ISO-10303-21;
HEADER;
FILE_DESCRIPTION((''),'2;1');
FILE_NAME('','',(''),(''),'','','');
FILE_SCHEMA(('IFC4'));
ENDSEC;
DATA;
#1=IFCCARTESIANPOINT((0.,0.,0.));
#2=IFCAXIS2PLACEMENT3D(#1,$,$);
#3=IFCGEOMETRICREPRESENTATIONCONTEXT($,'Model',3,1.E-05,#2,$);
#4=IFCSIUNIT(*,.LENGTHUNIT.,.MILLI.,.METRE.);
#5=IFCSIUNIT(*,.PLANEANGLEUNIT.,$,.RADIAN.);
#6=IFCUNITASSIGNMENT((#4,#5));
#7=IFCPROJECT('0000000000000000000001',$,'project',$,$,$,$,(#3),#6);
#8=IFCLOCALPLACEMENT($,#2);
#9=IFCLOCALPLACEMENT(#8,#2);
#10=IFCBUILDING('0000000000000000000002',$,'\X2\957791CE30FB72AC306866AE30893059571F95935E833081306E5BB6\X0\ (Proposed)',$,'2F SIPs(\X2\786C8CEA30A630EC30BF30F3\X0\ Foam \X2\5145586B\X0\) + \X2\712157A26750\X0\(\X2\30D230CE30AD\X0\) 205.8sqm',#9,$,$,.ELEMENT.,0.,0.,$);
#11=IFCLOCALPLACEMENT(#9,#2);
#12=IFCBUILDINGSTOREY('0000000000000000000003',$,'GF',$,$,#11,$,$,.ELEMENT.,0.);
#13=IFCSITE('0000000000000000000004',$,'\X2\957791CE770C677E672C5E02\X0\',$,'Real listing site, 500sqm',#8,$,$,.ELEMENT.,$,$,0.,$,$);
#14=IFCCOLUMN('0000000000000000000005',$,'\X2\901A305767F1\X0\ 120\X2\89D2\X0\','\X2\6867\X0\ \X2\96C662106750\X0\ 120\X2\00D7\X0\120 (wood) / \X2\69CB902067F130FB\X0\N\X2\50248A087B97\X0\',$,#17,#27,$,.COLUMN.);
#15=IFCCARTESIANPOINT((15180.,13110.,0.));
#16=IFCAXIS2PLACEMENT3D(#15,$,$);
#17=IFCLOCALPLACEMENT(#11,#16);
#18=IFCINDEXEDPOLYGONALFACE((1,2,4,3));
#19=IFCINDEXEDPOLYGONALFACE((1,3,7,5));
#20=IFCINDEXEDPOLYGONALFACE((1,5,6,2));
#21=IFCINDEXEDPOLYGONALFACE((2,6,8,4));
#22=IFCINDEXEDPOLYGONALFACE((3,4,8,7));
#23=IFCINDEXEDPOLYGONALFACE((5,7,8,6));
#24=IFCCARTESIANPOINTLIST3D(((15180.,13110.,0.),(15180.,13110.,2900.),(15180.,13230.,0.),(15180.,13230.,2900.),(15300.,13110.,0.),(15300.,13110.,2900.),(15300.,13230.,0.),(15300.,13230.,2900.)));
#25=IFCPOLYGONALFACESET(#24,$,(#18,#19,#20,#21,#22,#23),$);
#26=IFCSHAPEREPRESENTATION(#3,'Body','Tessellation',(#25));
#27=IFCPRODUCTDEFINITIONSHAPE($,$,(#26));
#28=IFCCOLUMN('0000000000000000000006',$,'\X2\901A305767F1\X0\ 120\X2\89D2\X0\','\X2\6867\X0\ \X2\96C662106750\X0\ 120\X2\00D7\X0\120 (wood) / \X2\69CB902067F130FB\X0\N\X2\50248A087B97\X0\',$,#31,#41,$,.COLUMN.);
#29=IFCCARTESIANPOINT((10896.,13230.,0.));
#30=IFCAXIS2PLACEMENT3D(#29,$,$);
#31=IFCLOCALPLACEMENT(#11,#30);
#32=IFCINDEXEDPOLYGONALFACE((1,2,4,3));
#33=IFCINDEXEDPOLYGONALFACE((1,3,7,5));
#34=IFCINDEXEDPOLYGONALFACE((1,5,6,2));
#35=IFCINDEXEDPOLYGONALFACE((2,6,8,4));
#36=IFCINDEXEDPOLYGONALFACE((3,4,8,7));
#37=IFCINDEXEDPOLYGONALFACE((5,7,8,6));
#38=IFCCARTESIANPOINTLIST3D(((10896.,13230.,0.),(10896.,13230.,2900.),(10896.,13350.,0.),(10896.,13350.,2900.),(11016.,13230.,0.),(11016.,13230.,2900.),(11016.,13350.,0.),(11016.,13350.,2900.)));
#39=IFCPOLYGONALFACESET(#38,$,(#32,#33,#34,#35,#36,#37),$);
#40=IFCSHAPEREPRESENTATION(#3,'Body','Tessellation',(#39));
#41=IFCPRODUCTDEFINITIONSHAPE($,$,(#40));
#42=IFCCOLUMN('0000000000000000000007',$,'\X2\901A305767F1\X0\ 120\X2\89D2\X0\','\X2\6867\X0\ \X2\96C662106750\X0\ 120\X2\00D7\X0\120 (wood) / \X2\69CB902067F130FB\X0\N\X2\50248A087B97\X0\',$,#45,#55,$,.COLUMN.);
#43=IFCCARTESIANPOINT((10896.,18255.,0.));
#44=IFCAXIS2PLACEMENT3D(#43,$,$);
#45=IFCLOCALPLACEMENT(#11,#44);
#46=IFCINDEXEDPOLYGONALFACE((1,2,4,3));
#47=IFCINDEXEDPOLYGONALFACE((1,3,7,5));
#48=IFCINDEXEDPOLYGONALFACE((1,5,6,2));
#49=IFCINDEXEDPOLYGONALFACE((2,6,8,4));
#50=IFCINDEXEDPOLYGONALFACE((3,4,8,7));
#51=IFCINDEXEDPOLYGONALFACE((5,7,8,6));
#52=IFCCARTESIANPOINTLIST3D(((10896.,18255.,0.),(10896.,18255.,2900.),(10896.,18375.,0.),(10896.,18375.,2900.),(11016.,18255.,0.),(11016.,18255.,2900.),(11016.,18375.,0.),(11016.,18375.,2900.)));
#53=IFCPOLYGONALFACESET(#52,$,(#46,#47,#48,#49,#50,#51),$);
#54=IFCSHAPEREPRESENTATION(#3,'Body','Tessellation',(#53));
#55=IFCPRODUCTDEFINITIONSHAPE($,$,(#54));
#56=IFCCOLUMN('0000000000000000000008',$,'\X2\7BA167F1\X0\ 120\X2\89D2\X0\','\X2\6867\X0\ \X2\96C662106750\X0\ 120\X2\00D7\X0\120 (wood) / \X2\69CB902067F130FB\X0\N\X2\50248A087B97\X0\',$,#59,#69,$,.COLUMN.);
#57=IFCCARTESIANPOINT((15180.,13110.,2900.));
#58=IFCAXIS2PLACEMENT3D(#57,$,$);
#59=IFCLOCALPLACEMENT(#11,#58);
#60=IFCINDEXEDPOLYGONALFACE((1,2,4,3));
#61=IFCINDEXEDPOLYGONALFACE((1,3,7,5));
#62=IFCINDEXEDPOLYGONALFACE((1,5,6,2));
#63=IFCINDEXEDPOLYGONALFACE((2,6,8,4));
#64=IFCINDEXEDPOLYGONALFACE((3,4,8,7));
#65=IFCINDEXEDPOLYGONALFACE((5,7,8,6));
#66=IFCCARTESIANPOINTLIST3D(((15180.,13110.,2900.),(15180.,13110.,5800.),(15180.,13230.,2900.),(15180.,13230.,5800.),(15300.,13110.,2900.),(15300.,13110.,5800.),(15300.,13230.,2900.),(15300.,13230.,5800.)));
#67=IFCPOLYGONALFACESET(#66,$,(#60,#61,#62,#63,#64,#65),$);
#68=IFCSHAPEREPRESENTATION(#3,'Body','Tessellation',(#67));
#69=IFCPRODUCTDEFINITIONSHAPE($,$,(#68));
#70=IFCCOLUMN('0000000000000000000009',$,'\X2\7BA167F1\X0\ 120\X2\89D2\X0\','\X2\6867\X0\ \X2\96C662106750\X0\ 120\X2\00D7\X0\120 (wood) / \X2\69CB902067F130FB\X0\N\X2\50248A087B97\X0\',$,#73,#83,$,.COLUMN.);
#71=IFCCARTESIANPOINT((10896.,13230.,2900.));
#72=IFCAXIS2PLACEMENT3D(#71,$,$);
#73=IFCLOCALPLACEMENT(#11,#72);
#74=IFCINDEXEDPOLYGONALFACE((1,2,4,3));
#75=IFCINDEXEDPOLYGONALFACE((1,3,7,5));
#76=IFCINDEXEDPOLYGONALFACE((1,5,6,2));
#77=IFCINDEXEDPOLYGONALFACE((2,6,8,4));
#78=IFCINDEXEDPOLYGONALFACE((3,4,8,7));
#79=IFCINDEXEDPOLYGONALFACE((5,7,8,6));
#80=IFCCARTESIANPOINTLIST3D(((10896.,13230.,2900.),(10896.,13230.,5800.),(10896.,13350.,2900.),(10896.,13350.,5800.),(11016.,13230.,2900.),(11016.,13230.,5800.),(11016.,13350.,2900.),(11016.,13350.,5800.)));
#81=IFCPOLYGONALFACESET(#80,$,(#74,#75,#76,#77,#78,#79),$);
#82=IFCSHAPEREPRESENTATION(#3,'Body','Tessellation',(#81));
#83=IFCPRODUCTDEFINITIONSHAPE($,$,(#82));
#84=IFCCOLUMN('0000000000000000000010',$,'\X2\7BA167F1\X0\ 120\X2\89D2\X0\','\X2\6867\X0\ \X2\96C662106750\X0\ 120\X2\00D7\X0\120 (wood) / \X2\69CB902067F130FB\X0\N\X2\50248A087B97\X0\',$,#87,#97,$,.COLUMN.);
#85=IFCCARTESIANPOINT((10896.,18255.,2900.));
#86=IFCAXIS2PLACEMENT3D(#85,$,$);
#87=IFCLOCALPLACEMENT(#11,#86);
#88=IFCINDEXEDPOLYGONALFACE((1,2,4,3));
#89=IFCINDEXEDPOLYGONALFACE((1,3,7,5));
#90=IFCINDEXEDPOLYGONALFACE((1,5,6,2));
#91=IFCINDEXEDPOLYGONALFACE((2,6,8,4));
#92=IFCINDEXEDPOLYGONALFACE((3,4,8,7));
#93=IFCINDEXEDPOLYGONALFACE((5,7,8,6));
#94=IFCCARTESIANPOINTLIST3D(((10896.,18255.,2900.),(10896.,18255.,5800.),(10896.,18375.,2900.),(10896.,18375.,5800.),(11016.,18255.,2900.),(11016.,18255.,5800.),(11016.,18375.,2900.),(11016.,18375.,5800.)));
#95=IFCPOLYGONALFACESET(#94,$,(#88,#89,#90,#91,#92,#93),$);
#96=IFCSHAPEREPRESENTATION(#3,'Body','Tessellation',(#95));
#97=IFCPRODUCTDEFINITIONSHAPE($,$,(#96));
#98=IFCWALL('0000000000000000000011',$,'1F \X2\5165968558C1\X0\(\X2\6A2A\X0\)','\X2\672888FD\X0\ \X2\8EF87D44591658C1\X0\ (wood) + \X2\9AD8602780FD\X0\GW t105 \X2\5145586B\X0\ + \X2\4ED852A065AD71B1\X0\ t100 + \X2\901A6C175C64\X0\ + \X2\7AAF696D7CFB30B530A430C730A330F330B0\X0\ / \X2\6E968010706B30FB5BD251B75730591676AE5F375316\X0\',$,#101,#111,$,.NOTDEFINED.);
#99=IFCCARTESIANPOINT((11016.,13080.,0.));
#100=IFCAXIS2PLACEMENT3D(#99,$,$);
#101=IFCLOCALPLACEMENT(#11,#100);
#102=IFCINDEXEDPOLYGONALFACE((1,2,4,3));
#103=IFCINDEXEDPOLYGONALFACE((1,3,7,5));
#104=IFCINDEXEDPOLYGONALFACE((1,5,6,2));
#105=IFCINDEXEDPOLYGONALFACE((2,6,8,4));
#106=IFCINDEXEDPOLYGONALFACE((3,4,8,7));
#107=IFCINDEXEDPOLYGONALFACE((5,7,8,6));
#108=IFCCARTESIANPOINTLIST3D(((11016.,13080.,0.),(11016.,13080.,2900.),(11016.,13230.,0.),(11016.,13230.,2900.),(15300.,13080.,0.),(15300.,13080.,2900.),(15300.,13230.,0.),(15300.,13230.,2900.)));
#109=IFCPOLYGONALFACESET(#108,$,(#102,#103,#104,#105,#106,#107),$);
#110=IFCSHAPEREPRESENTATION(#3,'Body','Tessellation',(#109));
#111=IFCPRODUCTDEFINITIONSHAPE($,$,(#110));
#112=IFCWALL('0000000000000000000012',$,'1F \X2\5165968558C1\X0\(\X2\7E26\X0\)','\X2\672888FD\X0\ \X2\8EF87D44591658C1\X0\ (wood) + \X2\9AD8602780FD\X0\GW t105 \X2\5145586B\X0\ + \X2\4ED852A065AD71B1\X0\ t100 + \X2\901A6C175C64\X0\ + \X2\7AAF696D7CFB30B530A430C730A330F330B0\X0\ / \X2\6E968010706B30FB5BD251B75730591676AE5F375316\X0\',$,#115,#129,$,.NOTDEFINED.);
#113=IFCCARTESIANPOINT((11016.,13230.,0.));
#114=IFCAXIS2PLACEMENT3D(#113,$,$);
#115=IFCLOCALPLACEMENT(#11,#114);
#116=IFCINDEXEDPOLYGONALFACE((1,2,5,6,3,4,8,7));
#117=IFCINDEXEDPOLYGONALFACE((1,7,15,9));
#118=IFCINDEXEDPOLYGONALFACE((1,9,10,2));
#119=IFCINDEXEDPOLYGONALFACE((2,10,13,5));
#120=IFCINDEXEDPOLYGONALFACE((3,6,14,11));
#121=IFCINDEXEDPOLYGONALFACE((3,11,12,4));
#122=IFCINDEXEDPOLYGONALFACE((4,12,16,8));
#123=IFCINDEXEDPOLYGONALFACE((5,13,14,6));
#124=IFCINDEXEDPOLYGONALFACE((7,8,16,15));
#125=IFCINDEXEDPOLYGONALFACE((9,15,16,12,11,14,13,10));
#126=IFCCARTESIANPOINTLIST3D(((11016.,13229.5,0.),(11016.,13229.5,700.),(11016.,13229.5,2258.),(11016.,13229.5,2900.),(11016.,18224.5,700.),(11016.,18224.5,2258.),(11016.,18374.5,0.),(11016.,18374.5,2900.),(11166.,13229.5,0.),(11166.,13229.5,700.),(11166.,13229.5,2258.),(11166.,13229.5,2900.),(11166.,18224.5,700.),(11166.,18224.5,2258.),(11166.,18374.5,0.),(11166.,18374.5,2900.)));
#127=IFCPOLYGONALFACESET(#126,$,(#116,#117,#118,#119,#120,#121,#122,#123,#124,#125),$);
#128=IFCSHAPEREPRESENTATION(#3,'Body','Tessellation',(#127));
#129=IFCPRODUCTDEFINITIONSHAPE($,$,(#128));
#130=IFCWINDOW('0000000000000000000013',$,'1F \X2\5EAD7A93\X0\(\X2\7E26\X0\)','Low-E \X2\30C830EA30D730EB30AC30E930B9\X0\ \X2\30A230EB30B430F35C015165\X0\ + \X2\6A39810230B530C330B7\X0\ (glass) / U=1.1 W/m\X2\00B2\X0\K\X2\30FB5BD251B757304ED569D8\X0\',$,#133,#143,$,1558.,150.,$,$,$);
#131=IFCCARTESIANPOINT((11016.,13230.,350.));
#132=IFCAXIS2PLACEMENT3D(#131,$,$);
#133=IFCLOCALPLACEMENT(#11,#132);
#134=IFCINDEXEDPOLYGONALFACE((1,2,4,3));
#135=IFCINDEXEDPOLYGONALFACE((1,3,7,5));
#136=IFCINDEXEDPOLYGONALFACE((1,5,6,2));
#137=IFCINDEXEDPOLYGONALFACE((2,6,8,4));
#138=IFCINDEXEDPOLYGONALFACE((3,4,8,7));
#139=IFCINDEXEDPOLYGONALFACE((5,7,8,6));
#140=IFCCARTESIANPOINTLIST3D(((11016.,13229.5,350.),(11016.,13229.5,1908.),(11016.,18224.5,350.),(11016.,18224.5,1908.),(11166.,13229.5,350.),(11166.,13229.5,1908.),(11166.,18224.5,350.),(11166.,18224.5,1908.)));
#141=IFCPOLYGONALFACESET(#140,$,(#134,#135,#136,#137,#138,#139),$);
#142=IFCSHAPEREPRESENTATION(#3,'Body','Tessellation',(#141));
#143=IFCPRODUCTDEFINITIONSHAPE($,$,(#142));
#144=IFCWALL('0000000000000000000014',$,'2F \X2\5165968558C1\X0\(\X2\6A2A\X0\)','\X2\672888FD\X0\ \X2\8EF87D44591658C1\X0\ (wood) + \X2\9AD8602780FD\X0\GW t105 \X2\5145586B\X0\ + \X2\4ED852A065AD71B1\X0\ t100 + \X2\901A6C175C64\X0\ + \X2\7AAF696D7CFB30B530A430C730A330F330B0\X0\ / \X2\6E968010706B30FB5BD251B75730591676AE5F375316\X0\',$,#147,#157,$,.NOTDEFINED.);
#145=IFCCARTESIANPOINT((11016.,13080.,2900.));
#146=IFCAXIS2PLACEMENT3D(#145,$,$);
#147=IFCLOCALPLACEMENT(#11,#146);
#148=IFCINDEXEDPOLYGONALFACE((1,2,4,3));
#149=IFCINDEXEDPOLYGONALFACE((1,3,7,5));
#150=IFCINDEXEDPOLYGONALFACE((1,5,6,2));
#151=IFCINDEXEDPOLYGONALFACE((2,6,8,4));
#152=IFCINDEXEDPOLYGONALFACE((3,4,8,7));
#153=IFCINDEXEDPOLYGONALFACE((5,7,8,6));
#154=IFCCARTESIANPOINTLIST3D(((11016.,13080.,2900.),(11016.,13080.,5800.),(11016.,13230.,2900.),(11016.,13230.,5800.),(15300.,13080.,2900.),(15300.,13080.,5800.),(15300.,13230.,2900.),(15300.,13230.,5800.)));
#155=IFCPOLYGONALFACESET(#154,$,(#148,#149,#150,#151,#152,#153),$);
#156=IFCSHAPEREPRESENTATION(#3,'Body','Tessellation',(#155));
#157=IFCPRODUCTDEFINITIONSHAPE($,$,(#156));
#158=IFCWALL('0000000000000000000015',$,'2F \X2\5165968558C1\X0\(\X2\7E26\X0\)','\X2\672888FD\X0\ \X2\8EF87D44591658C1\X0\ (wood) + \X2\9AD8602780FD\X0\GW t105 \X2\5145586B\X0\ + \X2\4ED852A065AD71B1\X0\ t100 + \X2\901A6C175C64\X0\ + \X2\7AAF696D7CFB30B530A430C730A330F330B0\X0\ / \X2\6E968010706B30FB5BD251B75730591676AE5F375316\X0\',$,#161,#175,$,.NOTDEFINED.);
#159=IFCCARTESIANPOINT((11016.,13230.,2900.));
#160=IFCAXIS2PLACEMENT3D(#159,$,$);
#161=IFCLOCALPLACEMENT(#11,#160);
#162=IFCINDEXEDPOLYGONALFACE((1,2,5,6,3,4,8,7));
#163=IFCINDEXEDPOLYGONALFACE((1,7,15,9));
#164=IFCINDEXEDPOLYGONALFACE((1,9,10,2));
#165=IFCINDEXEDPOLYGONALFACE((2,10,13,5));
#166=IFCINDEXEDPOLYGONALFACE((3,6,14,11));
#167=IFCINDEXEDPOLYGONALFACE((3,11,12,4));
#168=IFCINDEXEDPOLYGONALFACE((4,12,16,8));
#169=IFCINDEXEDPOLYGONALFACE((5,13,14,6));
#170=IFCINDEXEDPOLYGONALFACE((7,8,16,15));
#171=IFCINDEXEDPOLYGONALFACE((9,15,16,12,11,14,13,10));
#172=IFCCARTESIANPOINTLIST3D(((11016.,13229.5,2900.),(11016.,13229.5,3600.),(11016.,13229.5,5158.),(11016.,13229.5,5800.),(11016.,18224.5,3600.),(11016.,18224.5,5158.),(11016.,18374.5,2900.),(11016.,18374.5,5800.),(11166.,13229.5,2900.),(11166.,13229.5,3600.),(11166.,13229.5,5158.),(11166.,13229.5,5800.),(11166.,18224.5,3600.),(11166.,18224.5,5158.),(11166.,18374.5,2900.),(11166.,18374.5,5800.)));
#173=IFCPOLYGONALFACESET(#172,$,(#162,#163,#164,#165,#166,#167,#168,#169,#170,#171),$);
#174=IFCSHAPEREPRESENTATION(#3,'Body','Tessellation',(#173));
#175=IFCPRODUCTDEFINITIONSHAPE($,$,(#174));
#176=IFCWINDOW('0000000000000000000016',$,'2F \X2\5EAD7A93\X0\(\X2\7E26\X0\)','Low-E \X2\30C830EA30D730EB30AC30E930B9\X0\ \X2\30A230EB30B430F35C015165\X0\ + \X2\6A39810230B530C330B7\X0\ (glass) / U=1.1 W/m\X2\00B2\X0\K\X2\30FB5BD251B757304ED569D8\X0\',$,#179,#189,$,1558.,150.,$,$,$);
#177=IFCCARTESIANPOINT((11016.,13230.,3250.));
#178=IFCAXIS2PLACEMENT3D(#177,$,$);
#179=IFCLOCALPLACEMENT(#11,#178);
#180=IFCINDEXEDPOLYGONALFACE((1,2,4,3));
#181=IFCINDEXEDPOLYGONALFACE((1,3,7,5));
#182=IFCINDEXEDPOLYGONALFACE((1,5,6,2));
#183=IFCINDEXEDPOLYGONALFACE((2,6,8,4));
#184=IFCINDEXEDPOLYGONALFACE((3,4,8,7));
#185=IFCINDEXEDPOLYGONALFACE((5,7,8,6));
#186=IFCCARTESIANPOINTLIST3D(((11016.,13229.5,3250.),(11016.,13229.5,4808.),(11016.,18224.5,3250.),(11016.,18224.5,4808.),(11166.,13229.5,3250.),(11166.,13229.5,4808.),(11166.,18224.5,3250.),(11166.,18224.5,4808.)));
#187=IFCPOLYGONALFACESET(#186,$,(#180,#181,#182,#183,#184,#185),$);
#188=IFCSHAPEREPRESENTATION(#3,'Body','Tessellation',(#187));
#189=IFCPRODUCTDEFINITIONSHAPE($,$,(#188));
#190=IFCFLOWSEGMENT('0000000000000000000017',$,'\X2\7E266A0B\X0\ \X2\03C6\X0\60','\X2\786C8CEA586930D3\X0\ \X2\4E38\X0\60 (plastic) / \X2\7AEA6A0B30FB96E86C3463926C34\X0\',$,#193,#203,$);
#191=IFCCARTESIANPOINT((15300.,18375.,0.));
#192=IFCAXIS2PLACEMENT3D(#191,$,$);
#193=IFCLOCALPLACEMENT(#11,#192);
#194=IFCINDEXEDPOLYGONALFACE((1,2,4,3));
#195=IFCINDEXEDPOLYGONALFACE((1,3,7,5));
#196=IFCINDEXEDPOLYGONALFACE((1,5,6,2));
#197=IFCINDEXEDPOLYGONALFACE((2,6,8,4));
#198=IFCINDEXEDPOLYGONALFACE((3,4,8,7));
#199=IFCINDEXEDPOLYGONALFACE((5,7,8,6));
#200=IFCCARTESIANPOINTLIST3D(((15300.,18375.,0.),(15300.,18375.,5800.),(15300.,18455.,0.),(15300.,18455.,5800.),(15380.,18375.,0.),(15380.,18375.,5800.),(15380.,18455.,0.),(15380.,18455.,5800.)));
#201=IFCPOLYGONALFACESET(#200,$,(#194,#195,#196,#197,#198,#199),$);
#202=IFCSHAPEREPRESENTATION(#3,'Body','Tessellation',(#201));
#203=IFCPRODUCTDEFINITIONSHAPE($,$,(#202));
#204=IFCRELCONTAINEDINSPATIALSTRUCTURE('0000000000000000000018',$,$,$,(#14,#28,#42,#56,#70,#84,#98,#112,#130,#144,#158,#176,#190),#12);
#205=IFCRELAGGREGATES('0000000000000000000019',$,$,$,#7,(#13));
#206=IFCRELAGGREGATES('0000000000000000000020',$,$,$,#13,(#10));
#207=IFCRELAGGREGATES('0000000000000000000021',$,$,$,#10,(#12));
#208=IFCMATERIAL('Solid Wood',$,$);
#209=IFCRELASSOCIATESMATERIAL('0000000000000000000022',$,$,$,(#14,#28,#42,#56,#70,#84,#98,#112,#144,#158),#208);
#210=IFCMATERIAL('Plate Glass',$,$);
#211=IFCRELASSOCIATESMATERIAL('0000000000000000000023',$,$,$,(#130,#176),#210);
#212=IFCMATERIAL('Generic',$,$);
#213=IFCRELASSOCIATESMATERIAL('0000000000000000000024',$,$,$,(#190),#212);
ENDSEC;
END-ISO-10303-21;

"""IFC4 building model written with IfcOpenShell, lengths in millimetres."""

from ifc_helpers import new_model, si_unit, frame, frame_2d, origin, place, context, project, spatial, rectangle, extrude, material, element, fill, save


model = new_model("IFC4")

# Units and contexts
model_context = context("Model", 3, precision=1e-05, world=origin())
ifc_project = project(units=[si_unit("LENGTHUNIT", "METRE", prefix="MILLI"), si_unit("PLANEANGLEUNIT", "RADIAN")], contexts=[model_context])

# Site, building, storey
site_placement = place(None, origin())
site = spatial("IfcSite", under=ifc_project, at=site_placement, Name="長野県松本市", ObjectType="Real listing site, 500sqm", CompositionType="ELEMENT", RefElevation=0.0)
building_placement = place(site_placement, origin())
building = spatial("IfcBuilding", under=site, at=building_placement, Name="長野・犬と暮らす土間広めの家 (Proposed)", ObjectType="2F SIPs(硬質ウレタン Foam 充填) + 無垢材(ヒノキ) 205.8sqm", CompositionType="ELEMENT", ElevationOfRefHeight=0.0, ElevationOfTerrain=0.0)
storey_placement = place(building_placement, origin())
storey = spatial("IfcBuildingStorey", under=building, at=storey_placement, Name="GF", CompositionType="ELEMENT", Elevation=0.0)

# Columns
ifc_material_1 = material(Name="Solid Wood")
column_1_placement = place(storey_placement, frame((15180.0, 13110.0, 0.0)))
element("IfcColumn", 1, at=column_1_placement, inside=storey, material=ifc_material_1, Name="通し柱 120角", Description="桧 集成材 120×120 (wood) / 構造柱・N値計算", PredefinedType="COLUMN", context=model_context, shape_type="SweptSolid", body=[
    extrude(rectangle(XDim=120.0, YDim=120.0, at=frame_2d((60.0, 60.0))), frame((15180.0, 13110.0, 0.0)), (0.0, 0.0, 1.0), 2900.0),
])
column_2_placement = place(storey_placement, frame((10896.0, 13230.0, 0.0)))
element("IfcColumn", 2, at=column_2_placement, inside=storey, material=ifc_material_1, Name="通し柱 120角", Description="桧 集成材 120×120 (wood) / 構造柱・N値計算", PredefinedType="COLUMN", context=model_context, shape_type="SweptSolid", body=[
    extrude(rectangle(XDim=120.0, YDim=120.0, at=frame_2d((60.0, 60.0))), frame((10896.0, 13230.0, 0.0)), (0.0, 0.0, 1.0), 2900.0),
])
column_3_placement = place(storey_placement, frame((10896.0, 18255.0, 0.0)))
element("IfcColumn", 3, at=column_3_placement, inside=storey, material=ifc_material_1, Name="通し柱 120角", Description="桧 集成材 120×120 (wood) / 構造柱・N値計算", PredefinedType="COLUMN", context=model_context, shape_type="SweptSolid", body=[
    extrude(rectangle(XDim=120.0, YDim=120.0, at=frame_2d((60.0, 60.0))), frame((10896.0, 18255.0, 0.0)), (0.0, 0.0, 1.0), 2900.0),
])
column_4_placement = place(storey_placement, frame((15180.0, 13110.0, 2900.0)))
element("IfcColumn", 4, at=column_4_placement, inside=storey, material=ifc_material_1, Name="管柱 120角", Description="桧 集成材 120×120 (wood) / 構造柱・N値計算", PredefinedType="COLUMN", context=model_context, shape_type="SweptSolid", body=[
    extrude(rectangle(XDim=120.0, YDim=120.0, at=frame_2d((60.0, 60.0))), frame((15180.0, 13110.0, 2900.0)), (0.0, 0.0, 1.0), 2900.0),
])
column_5_placement = place(storey_placement, frame((10896.0, 13230.0, 2900.0)))
element("IfcColumn", 5, at=column_5_placement, inside=storey, material=ifc_material_1, Name="管柱 120角", Description="桧 集成材 120×120 (wood) / 構造柱・N値計算", PredefinedType="COLUMN", context=model_context, shape_type="SweptSolid", body=[
    extrude(rectangle(XDim=120.0, YDim=120.0, at=frame_2d((60.0, 60.0))), frame((10896.0, 13230.0, 2900.0)), (0.0, 0.0, 1.0), 2900.0),
])
column_6_placement = place(storey_placement, frame((10896.0, 18255.0, 2900.0)))
element("IfcColumn", 6, at=column_6_placement, inside=storey, material=ifc_material_1, Name="管柱 120角", Description="桧 集成材 120×120 (wood) / 構造柱・N値計算", PredefinedType="COLUMN", context=model_context, shape_type="SweptSolid", body=[
    extrude(rectangle(XDim=120.0, YDim=120.0, at=frame_2d((60.0, 60.0))), frame((10896.0, 18255.0, 2900.0)), (0.0, 0.0, 1.0), 2900.0),
])

# Wall
wall_1_placement = place(storey_placement, frame((11016.0, 13080.0, 0.0)))
element("IfcWall", 7, at=wall_1_placement, inside=storey, material=ifc_material_1, Name="1F 入隅壁(横)", Description="木製 軸組外壁 (wood) + 高性能GW t105 充填 + 付加断熱 t100 + 通気層 + 窯業系サイディング / 準耐火・寒冷地外皮強化", PredefinedType="NOTDEFINED", context=model_context, shape_type="SweptSolid", body=[
    extrude(rectangle(XDim=4284.0, YDim=150.0, at=frame_2d((2142.0, 75.0))), frame((11016.0, 13080.0, 0.0)), (0.0, 0.0, 1.0), 2900.0),
])

# Wall, opening, window
wall_2_placement = place(storey_placement, frame((11016.0, 13230.0, 0.0)))
wall_2 = element("IfcWall", 8, at=wall_2_placement, inside=storey, material=ifc_material_1, Name="1F 入隅壁(縦)", Description="木製 軸組外壁 (wood) + 高性能GW t105 充填 + 付加断熱 t100 + 通気層 + 窯業系サイディング / 準耐火・寒冷地外皮強化", PredefinedType="NOTDEFINED", context=model_context, shape_type="SweptSolid", body=[
    extrude(rectangle(XDim=150.0, YDim=5145.0, at=frame_2d((75.0, 2572.0))), frame((11016.0, 13230.0, 0.0)), (0.0, 0.0, 1.0), 2900.0),
])
opening_1_placement = place(storey_placement, frame((11016.0, 13230.0, 350.0)))
opening_1 = element("IfcOpeningElement", 9, at=opening_1_placement, cuts=wall_2, PredefinedType="NOTDEFINED", context=model_context, shape_type="SweptSolid", body=[
    extrude(rectangle(XDim=150.0, YDim=4995.0, at=frame_2d((75.0, 2497.0))), frame((11016.0, 13230.0, 350.0)), (0.0, 0.0, 1.0), 1558.0),
])
ifc_material_2 = material(Name="Plate Glass")
window_1_placement = place(storey_placement, frame((11016.0, 13230.0, 350.0)))
window_1 = element("IfcWindow", 10, at=window_1_placement, inside=storey, material=ifc_material_2, Name="1F 庭窓(縦)", Description="Low-E トリプルガラス アルゴン封入 + 樹脂サッシ (glass) / U=1.1 W/m²K・寒冷地仕様", OverallHeight=1558.0, OverallWidth=150.0, context=model_context, shape_type="SweptSolid", body=[
    extrude(rectangle(XDim=150.0, YDim=4995.0, at=frame_2d((75.0, 2497.0))), frame((11016.0, 13230.0, 350.0)), (0.0, 0.0, 1.0), 1558.0),
])
fill(opening_1, window_1)

# Wall
wall_3_placement = place(storey_placement, frame((11016.0, 13080.0, 2900.0)))
element("IfcWall", 11, at=wall_3_placement, inside=storey, material=ifc_material_1, Name="2F 入隅壁(横)", Description="木製 軸組外壁 (wood) + 高性能GW t105 充填 + 付加断熱 t100 + 通気層 + 窯業系サイディング / 準耐火・寒冷地外皮強化", PredefinedType="NOTDEFINED", context=model_context, shape_type="SweptSolid", body=[
    extrude(rectangle(XDim=4284.0, YDim=150.0, at=frame_2d((2142.0, 75.0))), frame((11016.0, 13080.0, 2900.0)), (0.0, 0.0, 1.0), 2900.0),
])

# Wall, opening, window
wall_4_placement = place(storey_placement, frame((11016.0, 13230.0, 2900.0)))
wall_4 = element("IfcWall", 12, at=wall_4_placement, inside=storey, material=ifc_material_1, Name="2F 入隅壁(縦)", Description="木製 軸組外壁 (wood) + 高性能GW t105 充填 + 付加断熱 t100 + 通気層 + 窯業系サイディング / 準耐火・寒冷地外皮強化", PredefinedType="NOTDEFINED", context=model_context, shape_type="SweptSolid", body=[
    extrude(rectangle(XDim=150.0, YDim=5145.0, at=frame_2d((75.0, 2572.0))), frame((11016.0, 13230.0, 2900.0)), (0.0, 0.0, 1.0), 2900.0),
])
opening_2_placement = place(storey_placement, frame((11016.0, 13230.0, 3250.0)))
opening_2 = element("IfcOpeningElement", 13, at=opening_2_placement, cuts=wall_4, PredefinedType="NOTDEFINED", context=model_context, shape_type="SweptSolid", body=[
    extrude(rectangle(XDim=150.0, YDim=4995.0, at=frame_2d((75.0, 2497.0))), frame((11016.0, 13230.0, 3250.0)), (0.0, 0.0, 1.0), 1558.0),
])
window_2_placement = place(storey_placement, frame((11016.0, 13230.0, 3250.0)))
window_2 = element("IfcWindow", 14, at=window_2_placement, inside=storey, material=ifc_material_2, Name="2F 庭窓(縦)", Description="Low-E トリプルガラス アルゴン封入 + 樹脂サッシ (glass) / U=1.1 W/m²K・寒冷地仕様", OverallHeight=1558.0, OverallWidth=150.0, context=model_context, shape_type="SweptSolid", body=[
    extrude(rectangle(XDim=150.0, YDim=4995.0, at=frame_2d((75.0, 2497.0))), frame((11016.0, 13230.0, 3250.0)), (0.0, 0.0, 1.0), 1558.0),
])
fill(opening_2, window_2)

# Flow segment
ifc_material_3 = material(Name="Generic")
flow_segment_placement = place(storey_placement, frame((15300.0, 18375.0, 0.0)))
element("IfcFlowSegment", 15, at=flow_segment_placement, inside=storey, material=ifc_material_3, Name="縦樋 φ60", Description="硬質塩ビ 丸60 (plastic) / 竪樋・雨水排水", context=model_context, shape_type="SweptSolid", body=[
    extrude(rectangle(XDim=80.0, YDim=80.0, at=frame_2d((40.0, 40.0))), frame((15300.0, 18375.0, 0.0)), (0.0, 0.0, 1.0), 5800.0),
])

save(model, "model.ifc")
